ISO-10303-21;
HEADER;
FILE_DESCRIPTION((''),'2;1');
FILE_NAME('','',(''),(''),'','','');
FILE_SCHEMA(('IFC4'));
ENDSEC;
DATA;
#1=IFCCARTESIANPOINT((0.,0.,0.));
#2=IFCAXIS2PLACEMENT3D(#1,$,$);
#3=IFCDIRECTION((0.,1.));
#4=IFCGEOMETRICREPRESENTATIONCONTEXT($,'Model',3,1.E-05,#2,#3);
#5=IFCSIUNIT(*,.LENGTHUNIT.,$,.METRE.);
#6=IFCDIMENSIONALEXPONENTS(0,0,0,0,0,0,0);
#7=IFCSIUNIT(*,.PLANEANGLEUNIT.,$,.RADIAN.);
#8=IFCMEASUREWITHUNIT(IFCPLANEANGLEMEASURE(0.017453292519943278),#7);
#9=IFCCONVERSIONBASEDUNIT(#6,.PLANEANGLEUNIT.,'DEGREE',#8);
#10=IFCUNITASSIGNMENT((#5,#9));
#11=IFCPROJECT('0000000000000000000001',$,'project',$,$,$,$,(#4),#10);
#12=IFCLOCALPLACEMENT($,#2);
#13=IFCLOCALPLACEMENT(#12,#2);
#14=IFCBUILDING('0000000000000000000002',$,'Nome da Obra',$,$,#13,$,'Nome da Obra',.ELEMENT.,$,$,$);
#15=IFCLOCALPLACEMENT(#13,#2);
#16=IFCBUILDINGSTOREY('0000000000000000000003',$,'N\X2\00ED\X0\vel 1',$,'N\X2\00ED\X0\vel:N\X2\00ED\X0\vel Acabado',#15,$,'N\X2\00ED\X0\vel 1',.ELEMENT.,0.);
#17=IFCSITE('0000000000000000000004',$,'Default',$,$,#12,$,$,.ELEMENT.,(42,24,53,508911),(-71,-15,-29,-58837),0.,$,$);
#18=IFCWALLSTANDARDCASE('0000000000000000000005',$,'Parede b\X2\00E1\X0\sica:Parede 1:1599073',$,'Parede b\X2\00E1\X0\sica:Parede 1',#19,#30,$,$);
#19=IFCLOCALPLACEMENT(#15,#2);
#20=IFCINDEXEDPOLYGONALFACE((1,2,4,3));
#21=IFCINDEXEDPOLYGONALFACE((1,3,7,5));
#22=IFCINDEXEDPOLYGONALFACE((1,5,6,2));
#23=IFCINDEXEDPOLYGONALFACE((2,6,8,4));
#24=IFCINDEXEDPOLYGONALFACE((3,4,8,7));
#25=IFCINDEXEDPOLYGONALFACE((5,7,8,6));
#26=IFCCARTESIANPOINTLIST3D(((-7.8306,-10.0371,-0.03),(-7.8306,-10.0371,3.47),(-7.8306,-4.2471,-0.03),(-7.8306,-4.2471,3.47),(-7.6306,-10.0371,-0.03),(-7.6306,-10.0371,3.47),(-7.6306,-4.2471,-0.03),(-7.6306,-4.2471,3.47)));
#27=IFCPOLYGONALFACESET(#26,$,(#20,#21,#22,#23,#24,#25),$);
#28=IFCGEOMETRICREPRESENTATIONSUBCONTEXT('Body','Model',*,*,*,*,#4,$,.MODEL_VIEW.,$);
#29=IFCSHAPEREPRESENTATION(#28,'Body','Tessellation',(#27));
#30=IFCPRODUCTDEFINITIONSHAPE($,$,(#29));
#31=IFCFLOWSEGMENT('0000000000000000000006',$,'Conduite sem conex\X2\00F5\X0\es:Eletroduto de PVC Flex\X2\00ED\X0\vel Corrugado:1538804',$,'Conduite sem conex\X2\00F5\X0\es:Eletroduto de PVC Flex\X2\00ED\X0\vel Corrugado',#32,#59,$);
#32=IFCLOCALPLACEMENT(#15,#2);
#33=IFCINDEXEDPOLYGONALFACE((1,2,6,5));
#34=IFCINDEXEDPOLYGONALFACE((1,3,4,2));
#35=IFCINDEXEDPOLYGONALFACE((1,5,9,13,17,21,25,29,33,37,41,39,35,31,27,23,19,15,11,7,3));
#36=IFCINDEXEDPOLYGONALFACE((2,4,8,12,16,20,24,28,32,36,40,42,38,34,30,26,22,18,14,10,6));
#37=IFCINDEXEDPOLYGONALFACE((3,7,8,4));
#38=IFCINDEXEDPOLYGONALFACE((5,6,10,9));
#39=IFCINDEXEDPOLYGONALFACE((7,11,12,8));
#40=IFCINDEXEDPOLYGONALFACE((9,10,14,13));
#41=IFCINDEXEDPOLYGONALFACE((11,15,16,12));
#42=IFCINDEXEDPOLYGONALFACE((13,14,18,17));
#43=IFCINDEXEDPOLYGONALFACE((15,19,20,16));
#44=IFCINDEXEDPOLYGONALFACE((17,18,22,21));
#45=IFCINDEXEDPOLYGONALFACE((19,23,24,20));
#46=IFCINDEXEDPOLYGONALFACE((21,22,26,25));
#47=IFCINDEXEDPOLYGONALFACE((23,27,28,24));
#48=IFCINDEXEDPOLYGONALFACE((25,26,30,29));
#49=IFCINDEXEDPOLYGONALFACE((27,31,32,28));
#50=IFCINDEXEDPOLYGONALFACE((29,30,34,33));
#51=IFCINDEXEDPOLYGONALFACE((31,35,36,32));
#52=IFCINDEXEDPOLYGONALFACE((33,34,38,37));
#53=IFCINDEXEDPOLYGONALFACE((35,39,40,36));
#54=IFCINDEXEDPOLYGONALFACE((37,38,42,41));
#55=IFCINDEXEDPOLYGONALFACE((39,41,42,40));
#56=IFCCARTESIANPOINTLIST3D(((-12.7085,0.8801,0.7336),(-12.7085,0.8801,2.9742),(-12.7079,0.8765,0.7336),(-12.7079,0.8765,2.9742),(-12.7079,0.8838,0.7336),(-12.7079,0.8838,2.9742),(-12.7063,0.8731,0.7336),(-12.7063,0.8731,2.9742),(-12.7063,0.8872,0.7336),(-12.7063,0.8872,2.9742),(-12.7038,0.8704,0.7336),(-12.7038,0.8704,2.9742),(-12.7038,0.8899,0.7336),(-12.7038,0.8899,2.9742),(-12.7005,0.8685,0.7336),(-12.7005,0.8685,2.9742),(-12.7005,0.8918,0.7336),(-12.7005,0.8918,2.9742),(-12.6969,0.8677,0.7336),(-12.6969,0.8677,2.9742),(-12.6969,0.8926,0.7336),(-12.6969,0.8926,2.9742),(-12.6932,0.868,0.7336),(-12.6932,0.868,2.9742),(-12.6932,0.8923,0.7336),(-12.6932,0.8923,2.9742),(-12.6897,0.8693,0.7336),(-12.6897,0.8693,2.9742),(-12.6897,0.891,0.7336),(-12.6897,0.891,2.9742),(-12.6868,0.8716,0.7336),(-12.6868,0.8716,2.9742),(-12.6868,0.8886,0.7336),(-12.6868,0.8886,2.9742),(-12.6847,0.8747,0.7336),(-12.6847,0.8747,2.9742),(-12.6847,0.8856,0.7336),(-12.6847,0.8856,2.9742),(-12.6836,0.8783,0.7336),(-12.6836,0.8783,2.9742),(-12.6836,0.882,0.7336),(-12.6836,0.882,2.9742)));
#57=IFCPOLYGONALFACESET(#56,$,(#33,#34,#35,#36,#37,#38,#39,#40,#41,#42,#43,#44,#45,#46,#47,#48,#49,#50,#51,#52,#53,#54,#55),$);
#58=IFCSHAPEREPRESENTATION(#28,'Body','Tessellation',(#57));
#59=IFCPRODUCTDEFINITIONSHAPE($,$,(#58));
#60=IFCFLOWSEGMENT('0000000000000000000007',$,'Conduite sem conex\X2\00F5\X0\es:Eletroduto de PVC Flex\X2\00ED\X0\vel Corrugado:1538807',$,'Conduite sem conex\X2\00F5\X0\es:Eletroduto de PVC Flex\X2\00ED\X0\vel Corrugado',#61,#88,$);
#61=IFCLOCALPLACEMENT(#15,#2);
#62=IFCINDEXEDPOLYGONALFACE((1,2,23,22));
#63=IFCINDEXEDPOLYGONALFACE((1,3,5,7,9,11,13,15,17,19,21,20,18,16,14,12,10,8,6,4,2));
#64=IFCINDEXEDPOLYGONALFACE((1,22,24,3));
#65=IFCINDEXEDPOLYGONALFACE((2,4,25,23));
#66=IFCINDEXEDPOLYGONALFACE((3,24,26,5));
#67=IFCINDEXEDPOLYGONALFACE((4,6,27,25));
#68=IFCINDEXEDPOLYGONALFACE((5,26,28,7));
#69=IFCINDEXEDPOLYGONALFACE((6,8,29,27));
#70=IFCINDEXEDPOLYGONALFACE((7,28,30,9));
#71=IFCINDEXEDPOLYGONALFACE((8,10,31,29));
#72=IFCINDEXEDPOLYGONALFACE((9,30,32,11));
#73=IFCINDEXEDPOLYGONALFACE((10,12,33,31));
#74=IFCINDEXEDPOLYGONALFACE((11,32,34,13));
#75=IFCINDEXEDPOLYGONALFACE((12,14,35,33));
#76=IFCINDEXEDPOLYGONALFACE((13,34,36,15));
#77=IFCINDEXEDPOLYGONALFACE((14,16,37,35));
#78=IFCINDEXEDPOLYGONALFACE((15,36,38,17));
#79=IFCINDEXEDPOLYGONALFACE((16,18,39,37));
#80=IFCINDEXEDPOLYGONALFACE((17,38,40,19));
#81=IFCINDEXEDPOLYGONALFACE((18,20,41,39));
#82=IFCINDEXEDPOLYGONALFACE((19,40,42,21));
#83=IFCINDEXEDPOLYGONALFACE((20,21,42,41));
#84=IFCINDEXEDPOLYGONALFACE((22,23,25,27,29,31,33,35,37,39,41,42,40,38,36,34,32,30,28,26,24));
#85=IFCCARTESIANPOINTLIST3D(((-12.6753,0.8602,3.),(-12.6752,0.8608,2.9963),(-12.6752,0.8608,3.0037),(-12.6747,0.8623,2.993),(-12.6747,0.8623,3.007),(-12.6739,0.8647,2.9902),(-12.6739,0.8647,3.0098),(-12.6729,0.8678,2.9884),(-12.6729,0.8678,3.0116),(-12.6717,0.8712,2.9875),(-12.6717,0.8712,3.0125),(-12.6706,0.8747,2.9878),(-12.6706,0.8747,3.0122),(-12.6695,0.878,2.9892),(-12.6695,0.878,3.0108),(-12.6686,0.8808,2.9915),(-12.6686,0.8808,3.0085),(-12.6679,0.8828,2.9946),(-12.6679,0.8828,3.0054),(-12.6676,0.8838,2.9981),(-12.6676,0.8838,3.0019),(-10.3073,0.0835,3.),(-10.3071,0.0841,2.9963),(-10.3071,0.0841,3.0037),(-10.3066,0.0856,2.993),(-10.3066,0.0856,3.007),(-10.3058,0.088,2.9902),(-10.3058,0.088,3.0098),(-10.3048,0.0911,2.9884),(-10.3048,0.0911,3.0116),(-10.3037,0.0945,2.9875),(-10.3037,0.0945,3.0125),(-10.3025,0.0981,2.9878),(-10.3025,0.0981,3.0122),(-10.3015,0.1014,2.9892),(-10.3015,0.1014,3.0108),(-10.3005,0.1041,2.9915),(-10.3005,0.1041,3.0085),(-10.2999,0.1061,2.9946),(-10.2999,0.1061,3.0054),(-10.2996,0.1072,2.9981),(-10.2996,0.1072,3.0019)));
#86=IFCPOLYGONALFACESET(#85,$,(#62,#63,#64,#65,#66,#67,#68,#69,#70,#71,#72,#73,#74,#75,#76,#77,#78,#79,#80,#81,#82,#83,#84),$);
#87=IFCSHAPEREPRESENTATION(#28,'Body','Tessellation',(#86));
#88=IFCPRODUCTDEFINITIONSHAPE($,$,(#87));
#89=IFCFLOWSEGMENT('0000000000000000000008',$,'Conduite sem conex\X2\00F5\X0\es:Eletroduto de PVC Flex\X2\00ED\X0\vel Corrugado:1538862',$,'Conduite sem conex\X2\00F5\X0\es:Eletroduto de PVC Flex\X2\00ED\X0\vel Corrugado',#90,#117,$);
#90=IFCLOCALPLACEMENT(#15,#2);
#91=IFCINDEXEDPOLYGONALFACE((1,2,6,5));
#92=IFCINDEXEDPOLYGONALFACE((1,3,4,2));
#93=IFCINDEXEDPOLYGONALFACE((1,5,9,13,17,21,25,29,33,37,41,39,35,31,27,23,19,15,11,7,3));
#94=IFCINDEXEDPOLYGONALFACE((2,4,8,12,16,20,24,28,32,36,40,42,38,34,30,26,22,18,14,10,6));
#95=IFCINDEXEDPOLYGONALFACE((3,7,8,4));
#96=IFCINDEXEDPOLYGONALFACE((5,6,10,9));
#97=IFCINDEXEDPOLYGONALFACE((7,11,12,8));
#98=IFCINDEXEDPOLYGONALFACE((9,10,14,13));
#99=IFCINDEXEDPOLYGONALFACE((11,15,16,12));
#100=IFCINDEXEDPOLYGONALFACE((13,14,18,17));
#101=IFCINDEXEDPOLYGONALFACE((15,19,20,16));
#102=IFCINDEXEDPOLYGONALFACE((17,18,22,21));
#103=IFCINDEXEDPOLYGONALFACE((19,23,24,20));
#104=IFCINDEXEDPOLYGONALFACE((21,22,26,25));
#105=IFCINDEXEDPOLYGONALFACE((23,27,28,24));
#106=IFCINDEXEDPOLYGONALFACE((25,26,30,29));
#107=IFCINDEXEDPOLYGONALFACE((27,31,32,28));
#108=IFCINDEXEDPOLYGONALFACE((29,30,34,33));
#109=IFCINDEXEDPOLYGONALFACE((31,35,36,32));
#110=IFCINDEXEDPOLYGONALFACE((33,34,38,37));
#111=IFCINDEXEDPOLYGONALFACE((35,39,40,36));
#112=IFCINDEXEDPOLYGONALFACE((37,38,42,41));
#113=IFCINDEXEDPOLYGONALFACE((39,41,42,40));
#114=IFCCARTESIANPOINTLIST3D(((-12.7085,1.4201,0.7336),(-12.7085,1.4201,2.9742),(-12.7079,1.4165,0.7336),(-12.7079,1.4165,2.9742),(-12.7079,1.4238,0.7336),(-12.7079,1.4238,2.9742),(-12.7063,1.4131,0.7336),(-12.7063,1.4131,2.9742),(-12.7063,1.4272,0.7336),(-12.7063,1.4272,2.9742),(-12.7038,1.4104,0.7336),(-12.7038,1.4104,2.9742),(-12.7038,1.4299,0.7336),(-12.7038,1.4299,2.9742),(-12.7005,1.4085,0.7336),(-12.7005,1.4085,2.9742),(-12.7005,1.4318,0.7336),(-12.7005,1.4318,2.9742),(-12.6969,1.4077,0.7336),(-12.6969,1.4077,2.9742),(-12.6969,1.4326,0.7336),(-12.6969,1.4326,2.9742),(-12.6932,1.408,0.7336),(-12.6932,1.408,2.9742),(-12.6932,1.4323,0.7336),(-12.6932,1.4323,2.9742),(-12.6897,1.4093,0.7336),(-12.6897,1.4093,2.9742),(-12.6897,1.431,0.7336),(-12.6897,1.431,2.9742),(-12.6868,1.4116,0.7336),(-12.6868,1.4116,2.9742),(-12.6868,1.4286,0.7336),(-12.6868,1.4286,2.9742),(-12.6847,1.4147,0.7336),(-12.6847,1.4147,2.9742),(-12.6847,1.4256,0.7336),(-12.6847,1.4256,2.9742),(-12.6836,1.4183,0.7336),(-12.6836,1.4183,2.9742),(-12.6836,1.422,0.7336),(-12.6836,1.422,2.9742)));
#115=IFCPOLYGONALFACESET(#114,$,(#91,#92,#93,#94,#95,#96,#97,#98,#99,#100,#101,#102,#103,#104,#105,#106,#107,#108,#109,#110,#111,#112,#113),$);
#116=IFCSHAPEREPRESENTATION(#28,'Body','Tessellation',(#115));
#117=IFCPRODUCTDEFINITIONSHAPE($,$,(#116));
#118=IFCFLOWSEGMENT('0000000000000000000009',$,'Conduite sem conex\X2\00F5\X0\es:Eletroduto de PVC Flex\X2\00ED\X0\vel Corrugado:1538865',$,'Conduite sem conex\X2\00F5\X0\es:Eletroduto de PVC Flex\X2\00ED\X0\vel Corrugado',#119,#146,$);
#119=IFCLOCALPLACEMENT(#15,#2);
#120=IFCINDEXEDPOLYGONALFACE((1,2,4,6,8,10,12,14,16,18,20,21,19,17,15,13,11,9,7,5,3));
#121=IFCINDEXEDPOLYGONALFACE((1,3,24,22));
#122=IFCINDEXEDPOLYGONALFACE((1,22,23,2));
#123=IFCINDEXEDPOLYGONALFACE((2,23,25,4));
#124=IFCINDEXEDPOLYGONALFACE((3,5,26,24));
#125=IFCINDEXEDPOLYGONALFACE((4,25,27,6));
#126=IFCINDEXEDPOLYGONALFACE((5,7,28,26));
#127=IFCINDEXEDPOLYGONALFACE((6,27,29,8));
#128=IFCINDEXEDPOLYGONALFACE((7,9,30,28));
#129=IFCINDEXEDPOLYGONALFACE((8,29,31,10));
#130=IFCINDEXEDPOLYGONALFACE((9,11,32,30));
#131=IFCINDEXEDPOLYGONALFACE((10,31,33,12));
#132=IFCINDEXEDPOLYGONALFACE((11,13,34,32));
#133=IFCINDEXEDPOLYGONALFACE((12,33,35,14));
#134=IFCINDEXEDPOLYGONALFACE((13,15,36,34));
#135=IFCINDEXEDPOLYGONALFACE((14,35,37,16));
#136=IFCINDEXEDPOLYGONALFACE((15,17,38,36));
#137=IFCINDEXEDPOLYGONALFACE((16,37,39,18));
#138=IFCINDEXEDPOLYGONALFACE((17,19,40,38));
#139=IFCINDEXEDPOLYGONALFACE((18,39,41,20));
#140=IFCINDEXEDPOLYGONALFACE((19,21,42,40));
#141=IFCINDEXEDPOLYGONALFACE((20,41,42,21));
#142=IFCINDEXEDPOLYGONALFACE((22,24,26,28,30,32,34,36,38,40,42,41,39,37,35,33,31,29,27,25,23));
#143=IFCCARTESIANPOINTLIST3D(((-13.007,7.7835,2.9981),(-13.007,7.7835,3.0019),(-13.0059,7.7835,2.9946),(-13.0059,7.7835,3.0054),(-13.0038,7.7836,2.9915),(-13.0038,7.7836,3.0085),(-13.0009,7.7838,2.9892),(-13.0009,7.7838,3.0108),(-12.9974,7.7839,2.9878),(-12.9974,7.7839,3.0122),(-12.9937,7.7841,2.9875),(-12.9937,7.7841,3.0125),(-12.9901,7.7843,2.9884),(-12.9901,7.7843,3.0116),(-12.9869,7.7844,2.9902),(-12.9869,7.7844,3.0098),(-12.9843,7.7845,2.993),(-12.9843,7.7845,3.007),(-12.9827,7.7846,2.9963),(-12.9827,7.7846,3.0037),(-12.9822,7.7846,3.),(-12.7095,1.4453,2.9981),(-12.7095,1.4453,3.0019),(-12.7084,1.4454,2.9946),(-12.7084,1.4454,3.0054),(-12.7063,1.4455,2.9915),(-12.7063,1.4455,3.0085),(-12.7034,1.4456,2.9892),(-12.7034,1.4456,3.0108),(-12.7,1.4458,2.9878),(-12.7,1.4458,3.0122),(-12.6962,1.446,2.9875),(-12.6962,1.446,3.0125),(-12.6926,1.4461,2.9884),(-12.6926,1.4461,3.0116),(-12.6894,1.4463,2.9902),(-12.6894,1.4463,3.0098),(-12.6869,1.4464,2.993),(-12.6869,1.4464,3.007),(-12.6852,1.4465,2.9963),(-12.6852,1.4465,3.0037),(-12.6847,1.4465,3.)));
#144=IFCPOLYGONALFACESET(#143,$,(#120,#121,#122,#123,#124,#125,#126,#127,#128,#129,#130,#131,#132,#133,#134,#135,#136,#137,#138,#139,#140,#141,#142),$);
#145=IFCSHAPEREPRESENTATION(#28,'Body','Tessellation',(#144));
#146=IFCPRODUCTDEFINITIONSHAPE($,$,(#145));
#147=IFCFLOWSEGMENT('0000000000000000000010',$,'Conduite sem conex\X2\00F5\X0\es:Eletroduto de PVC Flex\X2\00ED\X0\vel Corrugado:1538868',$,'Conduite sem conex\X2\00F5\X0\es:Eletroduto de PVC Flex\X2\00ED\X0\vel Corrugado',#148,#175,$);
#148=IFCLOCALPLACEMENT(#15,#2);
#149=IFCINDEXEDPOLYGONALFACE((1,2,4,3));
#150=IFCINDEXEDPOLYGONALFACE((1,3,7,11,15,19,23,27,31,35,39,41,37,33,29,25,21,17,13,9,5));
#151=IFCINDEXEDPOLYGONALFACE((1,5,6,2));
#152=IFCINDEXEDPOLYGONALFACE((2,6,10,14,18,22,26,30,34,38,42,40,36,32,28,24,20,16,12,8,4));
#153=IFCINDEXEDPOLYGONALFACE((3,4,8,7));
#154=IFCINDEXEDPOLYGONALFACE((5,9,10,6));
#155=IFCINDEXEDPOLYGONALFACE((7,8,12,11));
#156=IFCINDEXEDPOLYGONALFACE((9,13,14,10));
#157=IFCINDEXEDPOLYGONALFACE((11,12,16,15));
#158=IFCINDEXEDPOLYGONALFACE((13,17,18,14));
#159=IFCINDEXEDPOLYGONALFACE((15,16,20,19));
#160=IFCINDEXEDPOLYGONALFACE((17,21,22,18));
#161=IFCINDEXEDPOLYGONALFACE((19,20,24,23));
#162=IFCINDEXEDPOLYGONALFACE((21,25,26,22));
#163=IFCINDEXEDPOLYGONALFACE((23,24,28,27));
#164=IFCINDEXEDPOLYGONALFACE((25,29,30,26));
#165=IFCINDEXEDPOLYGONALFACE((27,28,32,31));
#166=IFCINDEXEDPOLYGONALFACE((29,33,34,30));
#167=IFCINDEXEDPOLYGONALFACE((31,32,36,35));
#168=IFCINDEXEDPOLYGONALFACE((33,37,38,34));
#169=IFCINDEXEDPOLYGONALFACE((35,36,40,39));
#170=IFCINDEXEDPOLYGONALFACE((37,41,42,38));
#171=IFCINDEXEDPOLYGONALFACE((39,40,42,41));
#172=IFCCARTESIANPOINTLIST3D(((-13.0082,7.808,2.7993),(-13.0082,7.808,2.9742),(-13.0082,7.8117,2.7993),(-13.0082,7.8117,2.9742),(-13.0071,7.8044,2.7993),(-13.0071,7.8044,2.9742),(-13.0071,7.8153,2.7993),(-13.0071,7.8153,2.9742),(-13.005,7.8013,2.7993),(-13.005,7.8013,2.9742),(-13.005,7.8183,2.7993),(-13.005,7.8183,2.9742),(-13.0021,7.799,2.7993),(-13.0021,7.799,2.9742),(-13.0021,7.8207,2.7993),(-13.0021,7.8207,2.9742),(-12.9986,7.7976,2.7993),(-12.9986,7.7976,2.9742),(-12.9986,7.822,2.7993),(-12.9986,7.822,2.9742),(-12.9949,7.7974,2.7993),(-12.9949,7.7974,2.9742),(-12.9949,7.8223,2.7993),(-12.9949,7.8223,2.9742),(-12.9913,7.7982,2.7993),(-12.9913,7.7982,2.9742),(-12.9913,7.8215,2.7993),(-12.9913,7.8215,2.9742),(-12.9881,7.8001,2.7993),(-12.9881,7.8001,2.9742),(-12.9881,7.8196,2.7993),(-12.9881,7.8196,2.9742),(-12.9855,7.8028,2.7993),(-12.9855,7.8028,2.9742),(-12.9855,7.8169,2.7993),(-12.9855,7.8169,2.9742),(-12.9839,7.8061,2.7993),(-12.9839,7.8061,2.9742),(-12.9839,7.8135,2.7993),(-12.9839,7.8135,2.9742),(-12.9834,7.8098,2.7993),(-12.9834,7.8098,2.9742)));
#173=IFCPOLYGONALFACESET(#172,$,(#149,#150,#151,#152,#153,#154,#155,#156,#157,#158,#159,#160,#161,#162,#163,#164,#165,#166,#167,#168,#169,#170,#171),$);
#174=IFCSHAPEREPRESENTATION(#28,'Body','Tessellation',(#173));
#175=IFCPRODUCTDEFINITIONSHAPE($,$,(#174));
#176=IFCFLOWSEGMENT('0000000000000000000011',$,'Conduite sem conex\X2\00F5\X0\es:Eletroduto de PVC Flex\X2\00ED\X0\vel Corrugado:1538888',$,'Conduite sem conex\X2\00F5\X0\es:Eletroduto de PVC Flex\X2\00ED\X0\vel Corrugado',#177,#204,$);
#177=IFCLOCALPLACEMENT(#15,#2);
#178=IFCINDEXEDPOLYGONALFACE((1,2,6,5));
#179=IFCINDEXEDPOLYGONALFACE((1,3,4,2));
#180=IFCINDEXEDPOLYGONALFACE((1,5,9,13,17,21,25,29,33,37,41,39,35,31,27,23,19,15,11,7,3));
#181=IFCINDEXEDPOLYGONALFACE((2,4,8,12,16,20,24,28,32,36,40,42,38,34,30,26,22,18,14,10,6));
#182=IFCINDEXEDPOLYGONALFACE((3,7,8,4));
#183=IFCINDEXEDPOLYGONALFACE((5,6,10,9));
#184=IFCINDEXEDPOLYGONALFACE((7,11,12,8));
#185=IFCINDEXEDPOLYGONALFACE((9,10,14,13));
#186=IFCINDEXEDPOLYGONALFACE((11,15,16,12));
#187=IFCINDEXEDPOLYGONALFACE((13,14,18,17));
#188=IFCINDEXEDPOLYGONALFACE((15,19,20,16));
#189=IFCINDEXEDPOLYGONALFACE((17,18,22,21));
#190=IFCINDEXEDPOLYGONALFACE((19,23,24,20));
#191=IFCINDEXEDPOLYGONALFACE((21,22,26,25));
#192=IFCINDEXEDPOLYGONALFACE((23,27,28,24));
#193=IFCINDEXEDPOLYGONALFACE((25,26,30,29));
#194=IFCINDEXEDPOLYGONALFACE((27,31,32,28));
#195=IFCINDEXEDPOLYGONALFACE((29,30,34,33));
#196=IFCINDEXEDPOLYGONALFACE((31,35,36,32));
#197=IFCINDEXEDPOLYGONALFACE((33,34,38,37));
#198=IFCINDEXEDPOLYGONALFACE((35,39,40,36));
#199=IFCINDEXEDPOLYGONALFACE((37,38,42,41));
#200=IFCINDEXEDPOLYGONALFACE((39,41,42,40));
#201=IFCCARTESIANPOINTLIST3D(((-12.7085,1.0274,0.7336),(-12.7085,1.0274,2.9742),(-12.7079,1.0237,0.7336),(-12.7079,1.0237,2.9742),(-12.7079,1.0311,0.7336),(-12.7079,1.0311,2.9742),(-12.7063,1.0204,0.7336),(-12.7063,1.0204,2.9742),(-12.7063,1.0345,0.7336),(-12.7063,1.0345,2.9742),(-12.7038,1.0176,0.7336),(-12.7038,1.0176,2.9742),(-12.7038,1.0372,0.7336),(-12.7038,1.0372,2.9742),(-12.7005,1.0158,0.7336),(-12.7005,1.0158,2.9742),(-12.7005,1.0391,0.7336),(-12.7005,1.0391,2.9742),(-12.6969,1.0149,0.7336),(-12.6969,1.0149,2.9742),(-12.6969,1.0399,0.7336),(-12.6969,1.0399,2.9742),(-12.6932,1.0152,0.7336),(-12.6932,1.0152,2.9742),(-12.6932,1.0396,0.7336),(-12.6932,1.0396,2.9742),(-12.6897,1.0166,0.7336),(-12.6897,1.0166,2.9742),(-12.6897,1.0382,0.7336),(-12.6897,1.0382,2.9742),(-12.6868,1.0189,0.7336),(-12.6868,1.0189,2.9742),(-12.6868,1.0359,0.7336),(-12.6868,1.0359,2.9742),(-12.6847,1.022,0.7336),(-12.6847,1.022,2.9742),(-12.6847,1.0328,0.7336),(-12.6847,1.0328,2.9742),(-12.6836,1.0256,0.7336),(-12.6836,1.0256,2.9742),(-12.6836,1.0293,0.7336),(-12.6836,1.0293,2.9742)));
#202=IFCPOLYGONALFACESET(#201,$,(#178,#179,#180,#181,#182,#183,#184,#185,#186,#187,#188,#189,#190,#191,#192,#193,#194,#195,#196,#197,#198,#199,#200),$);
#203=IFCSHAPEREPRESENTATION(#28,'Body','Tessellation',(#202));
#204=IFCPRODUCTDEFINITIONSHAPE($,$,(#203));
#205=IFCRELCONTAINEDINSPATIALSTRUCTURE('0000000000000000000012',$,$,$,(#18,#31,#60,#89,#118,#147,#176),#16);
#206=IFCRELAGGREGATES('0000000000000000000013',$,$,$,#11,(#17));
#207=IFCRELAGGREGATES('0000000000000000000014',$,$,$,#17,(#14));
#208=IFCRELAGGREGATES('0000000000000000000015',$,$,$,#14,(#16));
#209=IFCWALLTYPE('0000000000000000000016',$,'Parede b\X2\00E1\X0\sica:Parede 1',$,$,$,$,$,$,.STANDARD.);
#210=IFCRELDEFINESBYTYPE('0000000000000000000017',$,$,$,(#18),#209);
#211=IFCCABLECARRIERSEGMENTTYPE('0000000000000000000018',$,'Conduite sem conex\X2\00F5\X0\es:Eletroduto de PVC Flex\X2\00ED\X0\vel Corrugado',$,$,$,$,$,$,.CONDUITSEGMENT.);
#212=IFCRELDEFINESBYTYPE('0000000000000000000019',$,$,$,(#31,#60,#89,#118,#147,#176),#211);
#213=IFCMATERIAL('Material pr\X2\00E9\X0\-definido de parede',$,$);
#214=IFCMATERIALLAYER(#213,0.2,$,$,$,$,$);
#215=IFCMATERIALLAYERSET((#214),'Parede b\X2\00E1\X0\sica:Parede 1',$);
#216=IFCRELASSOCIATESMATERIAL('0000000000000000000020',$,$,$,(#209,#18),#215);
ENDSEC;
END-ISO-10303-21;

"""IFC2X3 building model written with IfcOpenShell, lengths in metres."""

from ifc_helpers import new_model, entity, si_unit, converted_unit, direction, frame, frame_2d, origin, origin_2d_with_axis, place, context, subcontext, project, spatial, rectangle, circle, extrude, material, layer, layer_set, layer_usage, type_object, element, save


model = new_model("IFC2X3")

# Units and contexts
model_context = context("Model", 3, precision=1e-05, world=origin(), true_north=direction((0.0, 1.0)))
body_context = subcontext(model_context, "Body", "Model", "MODEL_VIEW")
ifc_project = project(units=[si_unit("LENGTHUNIT", "METRE"), converted_unit("PLANEANGLEUNIT", "DEGREE", entity("IfcPlaneAngleMeasure", 0.017453292519943278), si_unit("PLANEANGLEUNIT", "RADIAN"), dimensions=[0, 0, 0, 0, 0, 0, 0])], contexts=[model_context])

# Site, building, storey
site_placement = place(None, origin())
site = spatial("IfcSite", under=ifc_project, at=site_placement, Name="Default", CompositionType="ELEMENT", RefLatitude=(42, 24, 53, 508911), RefLongitude=(-71, -15, -29, -58837), RefElevation=0.0)
building_placement = place(site_placement, origin())
building = spatial("IfcBuilding", under=site, at=building_placement, Name="Nome da Obra", LongName="Nome da Obra", CompositionType="ELEMENT")
storey_placement = place(building_placement, origin())
storey = spatial("IfcBuildingStorey", under=building, at=storey_placement, Name="Nível 1", ObjectType="Nível:Nível Acabado", LongName="Nível 1", CompositionType="ELEMENT", Elevation=0.0)

# Wall
ifc_material_1 = material(Name="Material pré-definido de parede")
ifc_layer = layer(ifc_material_1, 0.2)
ifc_layer_set = layer_set([ifc_layer], Name="Parede básica:Parede 1")
ifc_layer_usage = layer_usage(ifc_layer_set, "AXIS2", "NEGATIVE", 0.1)
wall_type = type_object("IfcWallType", Name="Parede básica:Parede 1", PredefinedType="STANDARD", material=ifc_layer_set)
wall_placement = place(storey_placement, frame((-7.7306, -10.0371, -0.03), z_axis=(0.0, 0.0, 1.0), x_axis=(0.0, 1.0, 0.0)))
element("IfcWallStandardCase", 1, at=wall_placement, inside=storey, type_object=wall_type, material=ifc_layer_usage, Name="Parede básica:Parede 1:1599073", ObjectType="Parede básica:Parede 1", context=body_context, shape_type="SweptSolid", body=[
    extrude(rectangle(XDim=5.79, YDim=0.2, at=frame_2d((2.895, 0.0), x_axis=(-1.0, 0.0))), origin(), (0.0, 0.0, 1.0), 3.5),
])

# Flow segments
cable_carrier_segment_type = type_object("IfcCableCarrierSegmentType", Name="Conduite sem conexões:Eletroduto de PVC Flexível Corrugado", PredefinedType="CONDUITSEGMENT")
flow_segment_1_placement = place(storey_placement, origin())
element("IfcFlowSegment", 2, at=flow_segment_1_placement, inside=storey, type_object=cable_carrier_segment_type, Name="Conduite sem conexões:Eletroduto de PVC Flexível Corrugado:1538804", ObjectType="Conduite sem conexões:Eletroduto de PVC Flexível Corrugado", context=body_context, shape_type="SweptSolid", body=[
    extrude(circle(Radius=0.0125, at=frame_2d((0.0, 0.0), x_axis=(1.0, 0.0))), frame((-12.696, 0.8801, 0.7336), z_axis=(0.0, 0.0, 1.0), x_axis=(-1.0, 0.0, 0.0)), (0.0, 0.0, 1.0), 2.2406),
])
flow_segment_2_placement = place(storey_placement, origin())
element("IfcFlowSegment", 3, at=flow_segment_2_placement, inside=storey, type_object=cable_carrier_segment_type, Name="Conduite sem conexões:Eletroduto de PVC Flexível Corrugado:1538807", ObjectType="Conduite sem conexões:Eletroduto de PVC Flexível Corrugado", context=body_context, shape_type="SweptSolid", body=[
    extrude(circle(Radius=0.0125, at=frame_2d((0.0, 0.0), x_axis=(1.0, 0.0))), frame((-12.6715, 0.8721, 3.0), z_axis=(0.950198, -0.311648, 0.0), x_axis=(-0.311648, -0.950198, 0.0)), (0.0, 0.0, 1.0), 2.4922),
])
flow_segment_3_placement = place(storey_placement, origin())
element("IfcFlowSegment", 4, at=flow_segment_3_placement, inside=storey, type_object=cable_carrier_segment_type, Name="Conduite sem conexões:Eletroduto de PVC Flexível Corrugado:1538862", ObjectType="Conduite sem conexões:Eletroduto de PVC Flexível Corrugado", context=body_context, shape_type="SweptSolid", body=[
    extrude(circle(Radius=0.0125, at=origin_2d_with_axis()), frame((-12.696, 1.4201, 0.7336), z_axis=(0.0, 0.0, 1.0), x_axis=(-1.0, 0.0, 0.0)), (0.0, 0.0, 1.0), 2.2406),
])
flow_segment_4_placement = place(storey_placement, origin())
element("IfcFlowSegment", 5, at=flow_segment_4_placement, inside=storey, type_object=cable_carrier_segment_type, Name="Conduite sem conexões:Eletroduto de PVC Flexível Corrugado:1538865", ObjectType="Conduite sem conexões:Eletroduto de PVC Flexível Corrugado", context=body_context, shape_type="SweptSolid", body=[
    extrude(circle(Radius=0.0125, at=origin_2d_with_axis()), frame((-12.9946, 7.7841, 3.0), z_axis=(0.046881, -0.9989, 0.0), x_axis=(0.9989, 0.046881, 0.0)), (0.0, 0.0, 1.0), 6.3451),
])
flow_segment_5_placement = place(storey_placement, origin())
element("IfcFlowSegment", 6, at=flow_segment_5_placement, inside=storey, type_object=cable_carrier_segment_type, Name="Conduite sem conexões:Eletroduto de PVC Flexível Corrugado:1538868", ObjectType="Conduite sem conexões:Eletroduto de PVC Flexível Corrugado", context=body_context, shape_type="SweptSolid", body=[
    extrude(circle(Radius=0.0125, at=origin_2d_with_axis()), frame((-12.9959, 7.8098, 2.7993)), (0.0, 0.0, 1.0), 0.1749),
])
flow_segment_6_placement = place(storey_placement, origin())
element("IfcFlowSegment", 7, at=flow_segment_6_placement, inside=storey, type_object=cable_carrier_segment_type, Name="Conduite sem conexões:Eletroduto de PVC Flexível Corrugado:1538888", ObjectType="Conduite sem conexões:Eletroduto de PVC Flexível Corrugado", context=body_context, shape_type="SweptSolid", body=[
    extrude(circle(Radius=0.0125, at=frame_2d((0.0, 0.0), x_axis=(1.0, 0.0))), frame((-12.696, 1.0274, 0.7336), z_axis=(0.0, 0.0, 1.0), x_axis=(-1.0, 0.0, 0.0)), (0.0, 0.0, 1.0), 2.2406),
])

save(model, "model.ifc")
